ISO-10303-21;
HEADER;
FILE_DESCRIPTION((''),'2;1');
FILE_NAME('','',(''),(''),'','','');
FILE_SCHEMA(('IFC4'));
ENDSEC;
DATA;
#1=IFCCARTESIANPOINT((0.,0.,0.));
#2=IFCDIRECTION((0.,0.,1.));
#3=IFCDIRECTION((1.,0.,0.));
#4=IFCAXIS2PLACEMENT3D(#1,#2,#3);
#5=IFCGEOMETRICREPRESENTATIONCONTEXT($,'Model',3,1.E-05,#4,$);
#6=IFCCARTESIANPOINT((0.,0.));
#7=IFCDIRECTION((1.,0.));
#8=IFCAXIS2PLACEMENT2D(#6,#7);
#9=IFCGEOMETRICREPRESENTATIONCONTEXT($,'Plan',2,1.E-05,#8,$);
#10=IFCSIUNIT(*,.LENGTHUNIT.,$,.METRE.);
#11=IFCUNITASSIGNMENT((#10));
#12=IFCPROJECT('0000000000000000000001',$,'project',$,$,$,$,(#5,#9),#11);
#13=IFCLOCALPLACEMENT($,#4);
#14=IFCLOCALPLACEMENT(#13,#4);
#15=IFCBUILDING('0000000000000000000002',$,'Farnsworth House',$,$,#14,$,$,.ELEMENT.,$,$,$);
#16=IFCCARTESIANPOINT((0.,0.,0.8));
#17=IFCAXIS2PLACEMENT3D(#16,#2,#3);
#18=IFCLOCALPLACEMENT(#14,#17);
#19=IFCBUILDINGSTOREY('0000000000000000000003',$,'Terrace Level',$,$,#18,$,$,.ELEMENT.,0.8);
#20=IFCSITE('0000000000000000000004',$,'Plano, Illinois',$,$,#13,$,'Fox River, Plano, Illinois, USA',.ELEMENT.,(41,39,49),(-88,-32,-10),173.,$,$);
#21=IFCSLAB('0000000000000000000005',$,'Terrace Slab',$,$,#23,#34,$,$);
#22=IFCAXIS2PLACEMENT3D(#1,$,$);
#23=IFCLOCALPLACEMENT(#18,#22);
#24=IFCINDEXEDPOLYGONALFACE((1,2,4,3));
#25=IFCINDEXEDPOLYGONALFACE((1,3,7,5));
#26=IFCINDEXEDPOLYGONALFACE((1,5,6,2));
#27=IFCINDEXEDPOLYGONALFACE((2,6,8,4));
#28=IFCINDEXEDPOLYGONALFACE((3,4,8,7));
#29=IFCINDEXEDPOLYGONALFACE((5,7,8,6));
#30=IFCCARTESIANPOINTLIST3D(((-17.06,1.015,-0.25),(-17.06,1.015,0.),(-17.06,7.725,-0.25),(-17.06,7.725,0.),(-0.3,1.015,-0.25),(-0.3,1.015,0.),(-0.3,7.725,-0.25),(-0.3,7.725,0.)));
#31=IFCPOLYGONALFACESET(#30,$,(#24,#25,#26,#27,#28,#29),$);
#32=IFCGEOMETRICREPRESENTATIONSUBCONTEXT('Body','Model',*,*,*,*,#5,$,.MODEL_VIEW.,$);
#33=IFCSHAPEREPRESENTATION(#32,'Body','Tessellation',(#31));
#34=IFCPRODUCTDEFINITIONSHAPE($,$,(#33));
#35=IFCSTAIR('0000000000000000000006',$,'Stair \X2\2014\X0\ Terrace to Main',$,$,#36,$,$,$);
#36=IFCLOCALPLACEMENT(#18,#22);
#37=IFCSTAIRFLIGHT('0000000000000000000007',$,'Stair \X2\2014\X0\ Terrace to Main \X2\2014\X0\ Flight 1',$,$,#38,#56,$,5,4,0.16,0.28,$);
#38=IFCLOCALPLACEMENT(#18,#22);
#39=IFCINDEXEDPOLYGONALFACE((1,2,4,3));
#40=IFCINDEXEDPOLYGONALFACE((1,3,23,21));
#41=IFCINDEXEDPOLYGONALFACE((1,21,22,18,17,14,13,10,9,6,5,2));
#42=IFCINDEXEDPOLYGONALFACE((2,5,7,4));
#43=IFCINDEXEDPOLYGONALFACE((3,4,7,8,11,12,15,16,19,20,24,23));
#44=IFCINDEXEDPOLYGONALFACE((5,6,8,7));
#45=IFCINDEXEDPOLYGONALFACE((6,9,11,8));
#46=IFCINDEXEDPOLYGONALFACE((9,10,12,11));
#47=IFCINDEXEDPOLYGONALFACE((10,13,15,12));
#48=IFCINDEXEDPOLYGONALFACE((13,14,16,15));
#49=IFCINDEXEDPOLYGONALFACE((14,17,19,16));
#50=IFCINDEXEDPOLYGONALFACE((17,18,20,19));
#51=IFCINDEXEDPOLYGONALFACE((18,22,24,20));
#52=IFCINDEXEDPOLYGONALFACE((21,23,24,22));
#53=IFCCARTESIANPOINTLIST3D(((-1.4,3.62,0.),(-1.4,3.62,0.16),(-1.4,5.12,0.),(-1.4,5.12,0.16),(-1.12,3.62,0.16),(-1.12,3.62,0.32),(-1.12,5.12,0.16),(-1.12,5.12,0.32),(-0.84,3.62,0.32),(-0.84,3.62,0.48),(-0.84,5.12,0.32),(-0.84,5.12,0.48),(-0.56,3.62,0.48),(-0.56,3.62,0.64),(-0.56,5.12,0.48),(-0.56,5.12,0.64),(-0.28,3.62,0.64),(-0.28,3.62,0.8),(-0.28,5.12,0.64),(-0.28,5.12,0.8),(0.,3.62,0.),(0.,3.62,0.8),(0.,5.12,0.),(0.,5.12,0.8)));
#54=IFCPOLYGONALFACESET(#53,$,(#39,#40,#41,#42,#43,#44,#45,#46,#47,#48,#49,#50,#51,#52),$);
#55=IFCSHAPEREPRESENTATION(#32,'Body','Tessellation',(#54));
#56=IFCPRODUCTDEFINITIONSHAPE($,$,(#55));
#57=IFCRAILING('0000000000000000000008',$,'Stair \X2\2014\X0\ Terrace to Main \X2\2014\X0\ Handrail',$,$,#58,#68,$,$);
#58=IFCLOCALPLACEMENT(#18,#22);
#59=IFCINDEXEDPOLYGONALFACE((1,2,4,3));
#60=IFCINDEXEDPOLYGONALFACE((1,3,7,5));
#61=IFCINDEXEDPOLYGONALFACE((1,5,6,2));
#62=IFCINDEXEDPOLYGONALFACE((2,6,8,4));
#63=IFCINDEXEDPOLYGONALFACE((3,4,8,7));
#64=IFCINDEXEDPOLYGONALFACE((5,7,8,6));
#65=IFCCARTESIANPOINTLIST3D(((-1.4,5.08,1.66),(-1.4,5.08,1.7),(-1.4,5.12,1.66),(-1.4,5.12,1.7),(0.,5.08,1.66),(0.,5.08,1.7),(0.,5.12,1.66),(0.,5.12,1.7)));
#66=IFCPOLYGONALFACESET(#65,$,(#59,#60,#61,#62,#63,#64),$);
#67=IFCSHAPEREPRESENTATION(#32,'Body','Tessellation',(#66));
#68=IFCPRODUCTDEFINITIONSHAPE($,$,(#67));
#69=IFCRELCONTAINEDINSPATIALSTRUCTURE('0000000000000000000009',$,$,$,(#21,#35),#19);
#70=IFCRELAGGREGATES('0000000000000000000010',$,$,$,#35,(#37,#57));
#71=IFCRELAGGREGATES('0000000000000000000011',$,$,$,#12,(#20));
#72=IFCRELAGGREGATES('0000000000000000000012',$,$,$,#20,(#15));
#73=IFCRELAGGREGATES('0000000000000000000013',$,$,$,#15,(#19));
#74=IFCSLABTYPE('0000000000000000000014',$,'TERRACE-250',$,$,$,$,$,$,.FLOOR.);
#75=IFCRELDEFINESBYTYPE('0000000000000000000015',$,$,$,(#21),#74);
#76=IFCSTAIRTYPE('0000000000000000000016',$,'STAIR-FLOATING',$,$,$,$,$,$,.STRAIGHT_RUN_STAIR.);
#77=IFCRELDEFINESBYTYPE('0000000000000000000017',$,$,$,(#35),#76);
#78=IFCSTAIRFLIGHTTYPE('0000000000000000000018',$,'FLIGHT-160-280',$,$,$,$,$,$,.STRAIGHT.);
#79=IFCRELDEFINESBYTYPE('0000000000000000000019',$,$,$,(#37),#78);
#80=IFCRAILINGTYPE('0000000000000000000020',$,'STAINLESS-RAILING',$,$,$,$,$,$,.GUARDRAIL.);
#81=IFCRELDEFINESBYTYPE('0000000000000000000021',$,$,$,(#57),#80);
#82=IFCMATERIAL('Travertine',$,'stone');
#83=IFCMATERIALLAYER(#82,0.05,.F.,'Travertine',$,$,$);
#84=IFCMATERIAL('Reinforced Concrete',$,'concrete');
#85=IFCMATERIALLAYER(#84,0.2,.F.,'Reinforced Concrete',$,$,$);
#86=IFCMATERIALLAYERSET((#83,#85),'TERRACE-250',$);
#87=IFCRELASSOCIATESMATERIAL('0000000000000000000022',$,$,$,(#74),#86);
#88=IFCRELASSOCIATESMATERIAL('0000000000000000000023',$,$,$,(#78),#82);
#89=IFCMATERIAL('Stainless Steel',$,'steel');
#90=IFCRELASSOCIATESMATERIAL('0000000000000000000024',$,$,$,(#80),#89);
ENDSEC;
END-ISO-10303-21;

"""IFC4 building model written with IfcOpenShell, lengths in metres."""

from ifc_helpers import new_model, si_unit, frame, origin_with_axes, origin_2d_with_axis, place, context, subcontext, project, spatial, polyline, rectangle, outline, extrude, material, layer, layer_set, layer_usage, type_object, element, aggregate, save


model = new_model("IFC4")

# Units and contexts
model_context = context("Model", 3, precision=1e-05, world=origin_with_axes())
plan_context = context("Plan", 2, precision=1e-05, world=origin_2d_with_axis())
body_context = subcontext(model_context, "Body", "Model", "MODEL_VIEW")
ifc_project = project(units=[si_unit("LENGTHUNIT", "METRE")], contexts=[model_context, plan_context])

# Site, building, storey
site_placement = place(None, origin_with_axes())
site = spatial("IfcSite", under=ifc_project, at=site_placement, Name="Plano, Illinois", LongName="Fox River, Plano, Illinois, USA", CompositionType="ELEMENT", RefLatitude=(41, 39, 49), RefLongitude=(-88, -32, -10), RefElevation=173.0)
building_placement = place(site_placement, origin_with_axes())
building = spatial("IfcBuilding", under=site, at=building_placement, Name="Farnsworth House", CompositionType="ELEMENT")
storey_placement = place(building_placement, frame((0.0, 0.0, 0.8), z_axis=(0.0, 0.0, 1.0), x_axis=(1.0, 0.0, 0.0)))
storey = spatial("IfcBuildingStorey", under=building, at=storey_placement, Name="Terrace Level", CompositionType="ELEMENT", Elevation=0.8)

# Slab
ifc_material_1 = material(Name="Travertine", Category="stone")
ifc_layer_1 = layer(ifc_material_1, 0.05, ventilated=False, Name="Travertine")
ifc_material_2 = material(Name="Reinforced Concrete", Category="concrete")
ifc_layer_2 = layer(ifc_material_2, 0.2, ventilated=False, Name="Reinforced Concrete")
ifc_layer_set = layer_set([ifc_layer_1, ifc_layer_2], Name="TERRACE-250")
ifc_layer_usage = layer_usage(ifc_layer_set, "AXIS3", "POSITIVE", -0.25)
slab_type = type_object("IfcSlabType", Name="TERRACE-250", PredefinedType="FLOOR", material=ifc_layer_usage)
slab_placement = place(storey_placement, frame((-17.06, 1.015, -0.25), z_axis=(0.0, 0.0, 1.0), x_axis=(1.0, 0.0, 0.0)))
element("IfcSlab", 1, at=slab_placement, inside=storey, type_object=slab_type, Name="Terrace Slab", context=body_context, shape_type="SweptSolid", body=[
    extrude(rectangle(XDim=16.76, YDim=6.71, at=origin_2d_with_axis()), frame((8.38, 3.355, 0.0), z_axis=(0.0, 0.0, 1.0), x_axis=(1.0, 0.0, 0.0)), (0.0, 0.0, 1.0), 0.25),
])

# Stair, stair flight, railing
stair_type = type_object("IfcStairType", Name="STAIR-FLOATING", PredefinedType="STRAIGHT_RUN_STAIR")
stair_placement = place(storey_placement, frame((-1.4, 3.62, 0.0), z_axis=(0.0, 0.0, 1.0), x_axis=(1.0, 0.0, 0.0)))
stair = element("IfcStair", 2, at=stair_placement, inside=storey, type_object=stair_type, Name="Stair — Terrace to Main")
stair_flight_type = type_object("IfcStairFlightType", Name="FLIGHT-160-280", PredefinedType="STRAIGHT", material=ifc_material_1)
stair_flight_placement = place(stair_placement, origin_with_axes())
stair_flight = element("IfcStairFlight", 3, at=stair_flight_placement, type_object=stair_flight_type, Name="Stair — Terrace to Main — Flight 1", NumberOfRisers=5, NumberOfTreads=4, RiserHeight=0.16, TreadLength=0.28, context=body_context, shape_type="SweptSolid", body=[
    extrude(outline(polyline([(0.0, 0.0), (0.0, 0.16), (0.28, 0.16), (0.28, 0.32), (0.56, 0.32), (0.56, 0.48), (0.84, 0.48), (0.84, 0.64), (1.12, 0.64), (1.12, 0.8), (1.4, 0.8), (1.4, 0.0), (0.0, 0.0)])), frame((0.0, 0.0, 0.0), z_axis=(0.0, -1.0, 0.0), x_axis=(1.0, 0.0, 0.0)), (0.0, 0.0, -1.0), 1.5),
])
ifc_material_3 = material(Name="Stainless Steel", Category="steel")
railing_type = type_object("IfcRailingType", Name="STAINLESS-RAILING", PredefinedType="GUARDRAIL", material=ifc_material_3)
railing_placement = place(stair_placement, frame((0.0, 1.46, 1.66), z_axis=(0.0, 0.0, 1.0), x_axis=(1.0, 0.0, 0.0)))
railing = element("IfcRailing", 4, at=railing_placement, type_object=railing_type, Name="Stair — Terrace to Main — Handrail", context=body_context, shape_type="SweptSolid", body=[
    extrude(rectangle(XDim=1.4, YDim=0.04, at=origin_2d_with_axis()), frame((0.7, 0.02, 0.0), z_axis=(0.0, 0.0, 1.0), x_axis=(1.0, 0.0, 0.0)), (0.0, 0.0, 1.0), 0.04),
])
aggregate(stair, [stair_flight, railing])

save(model, "model.ifc")
